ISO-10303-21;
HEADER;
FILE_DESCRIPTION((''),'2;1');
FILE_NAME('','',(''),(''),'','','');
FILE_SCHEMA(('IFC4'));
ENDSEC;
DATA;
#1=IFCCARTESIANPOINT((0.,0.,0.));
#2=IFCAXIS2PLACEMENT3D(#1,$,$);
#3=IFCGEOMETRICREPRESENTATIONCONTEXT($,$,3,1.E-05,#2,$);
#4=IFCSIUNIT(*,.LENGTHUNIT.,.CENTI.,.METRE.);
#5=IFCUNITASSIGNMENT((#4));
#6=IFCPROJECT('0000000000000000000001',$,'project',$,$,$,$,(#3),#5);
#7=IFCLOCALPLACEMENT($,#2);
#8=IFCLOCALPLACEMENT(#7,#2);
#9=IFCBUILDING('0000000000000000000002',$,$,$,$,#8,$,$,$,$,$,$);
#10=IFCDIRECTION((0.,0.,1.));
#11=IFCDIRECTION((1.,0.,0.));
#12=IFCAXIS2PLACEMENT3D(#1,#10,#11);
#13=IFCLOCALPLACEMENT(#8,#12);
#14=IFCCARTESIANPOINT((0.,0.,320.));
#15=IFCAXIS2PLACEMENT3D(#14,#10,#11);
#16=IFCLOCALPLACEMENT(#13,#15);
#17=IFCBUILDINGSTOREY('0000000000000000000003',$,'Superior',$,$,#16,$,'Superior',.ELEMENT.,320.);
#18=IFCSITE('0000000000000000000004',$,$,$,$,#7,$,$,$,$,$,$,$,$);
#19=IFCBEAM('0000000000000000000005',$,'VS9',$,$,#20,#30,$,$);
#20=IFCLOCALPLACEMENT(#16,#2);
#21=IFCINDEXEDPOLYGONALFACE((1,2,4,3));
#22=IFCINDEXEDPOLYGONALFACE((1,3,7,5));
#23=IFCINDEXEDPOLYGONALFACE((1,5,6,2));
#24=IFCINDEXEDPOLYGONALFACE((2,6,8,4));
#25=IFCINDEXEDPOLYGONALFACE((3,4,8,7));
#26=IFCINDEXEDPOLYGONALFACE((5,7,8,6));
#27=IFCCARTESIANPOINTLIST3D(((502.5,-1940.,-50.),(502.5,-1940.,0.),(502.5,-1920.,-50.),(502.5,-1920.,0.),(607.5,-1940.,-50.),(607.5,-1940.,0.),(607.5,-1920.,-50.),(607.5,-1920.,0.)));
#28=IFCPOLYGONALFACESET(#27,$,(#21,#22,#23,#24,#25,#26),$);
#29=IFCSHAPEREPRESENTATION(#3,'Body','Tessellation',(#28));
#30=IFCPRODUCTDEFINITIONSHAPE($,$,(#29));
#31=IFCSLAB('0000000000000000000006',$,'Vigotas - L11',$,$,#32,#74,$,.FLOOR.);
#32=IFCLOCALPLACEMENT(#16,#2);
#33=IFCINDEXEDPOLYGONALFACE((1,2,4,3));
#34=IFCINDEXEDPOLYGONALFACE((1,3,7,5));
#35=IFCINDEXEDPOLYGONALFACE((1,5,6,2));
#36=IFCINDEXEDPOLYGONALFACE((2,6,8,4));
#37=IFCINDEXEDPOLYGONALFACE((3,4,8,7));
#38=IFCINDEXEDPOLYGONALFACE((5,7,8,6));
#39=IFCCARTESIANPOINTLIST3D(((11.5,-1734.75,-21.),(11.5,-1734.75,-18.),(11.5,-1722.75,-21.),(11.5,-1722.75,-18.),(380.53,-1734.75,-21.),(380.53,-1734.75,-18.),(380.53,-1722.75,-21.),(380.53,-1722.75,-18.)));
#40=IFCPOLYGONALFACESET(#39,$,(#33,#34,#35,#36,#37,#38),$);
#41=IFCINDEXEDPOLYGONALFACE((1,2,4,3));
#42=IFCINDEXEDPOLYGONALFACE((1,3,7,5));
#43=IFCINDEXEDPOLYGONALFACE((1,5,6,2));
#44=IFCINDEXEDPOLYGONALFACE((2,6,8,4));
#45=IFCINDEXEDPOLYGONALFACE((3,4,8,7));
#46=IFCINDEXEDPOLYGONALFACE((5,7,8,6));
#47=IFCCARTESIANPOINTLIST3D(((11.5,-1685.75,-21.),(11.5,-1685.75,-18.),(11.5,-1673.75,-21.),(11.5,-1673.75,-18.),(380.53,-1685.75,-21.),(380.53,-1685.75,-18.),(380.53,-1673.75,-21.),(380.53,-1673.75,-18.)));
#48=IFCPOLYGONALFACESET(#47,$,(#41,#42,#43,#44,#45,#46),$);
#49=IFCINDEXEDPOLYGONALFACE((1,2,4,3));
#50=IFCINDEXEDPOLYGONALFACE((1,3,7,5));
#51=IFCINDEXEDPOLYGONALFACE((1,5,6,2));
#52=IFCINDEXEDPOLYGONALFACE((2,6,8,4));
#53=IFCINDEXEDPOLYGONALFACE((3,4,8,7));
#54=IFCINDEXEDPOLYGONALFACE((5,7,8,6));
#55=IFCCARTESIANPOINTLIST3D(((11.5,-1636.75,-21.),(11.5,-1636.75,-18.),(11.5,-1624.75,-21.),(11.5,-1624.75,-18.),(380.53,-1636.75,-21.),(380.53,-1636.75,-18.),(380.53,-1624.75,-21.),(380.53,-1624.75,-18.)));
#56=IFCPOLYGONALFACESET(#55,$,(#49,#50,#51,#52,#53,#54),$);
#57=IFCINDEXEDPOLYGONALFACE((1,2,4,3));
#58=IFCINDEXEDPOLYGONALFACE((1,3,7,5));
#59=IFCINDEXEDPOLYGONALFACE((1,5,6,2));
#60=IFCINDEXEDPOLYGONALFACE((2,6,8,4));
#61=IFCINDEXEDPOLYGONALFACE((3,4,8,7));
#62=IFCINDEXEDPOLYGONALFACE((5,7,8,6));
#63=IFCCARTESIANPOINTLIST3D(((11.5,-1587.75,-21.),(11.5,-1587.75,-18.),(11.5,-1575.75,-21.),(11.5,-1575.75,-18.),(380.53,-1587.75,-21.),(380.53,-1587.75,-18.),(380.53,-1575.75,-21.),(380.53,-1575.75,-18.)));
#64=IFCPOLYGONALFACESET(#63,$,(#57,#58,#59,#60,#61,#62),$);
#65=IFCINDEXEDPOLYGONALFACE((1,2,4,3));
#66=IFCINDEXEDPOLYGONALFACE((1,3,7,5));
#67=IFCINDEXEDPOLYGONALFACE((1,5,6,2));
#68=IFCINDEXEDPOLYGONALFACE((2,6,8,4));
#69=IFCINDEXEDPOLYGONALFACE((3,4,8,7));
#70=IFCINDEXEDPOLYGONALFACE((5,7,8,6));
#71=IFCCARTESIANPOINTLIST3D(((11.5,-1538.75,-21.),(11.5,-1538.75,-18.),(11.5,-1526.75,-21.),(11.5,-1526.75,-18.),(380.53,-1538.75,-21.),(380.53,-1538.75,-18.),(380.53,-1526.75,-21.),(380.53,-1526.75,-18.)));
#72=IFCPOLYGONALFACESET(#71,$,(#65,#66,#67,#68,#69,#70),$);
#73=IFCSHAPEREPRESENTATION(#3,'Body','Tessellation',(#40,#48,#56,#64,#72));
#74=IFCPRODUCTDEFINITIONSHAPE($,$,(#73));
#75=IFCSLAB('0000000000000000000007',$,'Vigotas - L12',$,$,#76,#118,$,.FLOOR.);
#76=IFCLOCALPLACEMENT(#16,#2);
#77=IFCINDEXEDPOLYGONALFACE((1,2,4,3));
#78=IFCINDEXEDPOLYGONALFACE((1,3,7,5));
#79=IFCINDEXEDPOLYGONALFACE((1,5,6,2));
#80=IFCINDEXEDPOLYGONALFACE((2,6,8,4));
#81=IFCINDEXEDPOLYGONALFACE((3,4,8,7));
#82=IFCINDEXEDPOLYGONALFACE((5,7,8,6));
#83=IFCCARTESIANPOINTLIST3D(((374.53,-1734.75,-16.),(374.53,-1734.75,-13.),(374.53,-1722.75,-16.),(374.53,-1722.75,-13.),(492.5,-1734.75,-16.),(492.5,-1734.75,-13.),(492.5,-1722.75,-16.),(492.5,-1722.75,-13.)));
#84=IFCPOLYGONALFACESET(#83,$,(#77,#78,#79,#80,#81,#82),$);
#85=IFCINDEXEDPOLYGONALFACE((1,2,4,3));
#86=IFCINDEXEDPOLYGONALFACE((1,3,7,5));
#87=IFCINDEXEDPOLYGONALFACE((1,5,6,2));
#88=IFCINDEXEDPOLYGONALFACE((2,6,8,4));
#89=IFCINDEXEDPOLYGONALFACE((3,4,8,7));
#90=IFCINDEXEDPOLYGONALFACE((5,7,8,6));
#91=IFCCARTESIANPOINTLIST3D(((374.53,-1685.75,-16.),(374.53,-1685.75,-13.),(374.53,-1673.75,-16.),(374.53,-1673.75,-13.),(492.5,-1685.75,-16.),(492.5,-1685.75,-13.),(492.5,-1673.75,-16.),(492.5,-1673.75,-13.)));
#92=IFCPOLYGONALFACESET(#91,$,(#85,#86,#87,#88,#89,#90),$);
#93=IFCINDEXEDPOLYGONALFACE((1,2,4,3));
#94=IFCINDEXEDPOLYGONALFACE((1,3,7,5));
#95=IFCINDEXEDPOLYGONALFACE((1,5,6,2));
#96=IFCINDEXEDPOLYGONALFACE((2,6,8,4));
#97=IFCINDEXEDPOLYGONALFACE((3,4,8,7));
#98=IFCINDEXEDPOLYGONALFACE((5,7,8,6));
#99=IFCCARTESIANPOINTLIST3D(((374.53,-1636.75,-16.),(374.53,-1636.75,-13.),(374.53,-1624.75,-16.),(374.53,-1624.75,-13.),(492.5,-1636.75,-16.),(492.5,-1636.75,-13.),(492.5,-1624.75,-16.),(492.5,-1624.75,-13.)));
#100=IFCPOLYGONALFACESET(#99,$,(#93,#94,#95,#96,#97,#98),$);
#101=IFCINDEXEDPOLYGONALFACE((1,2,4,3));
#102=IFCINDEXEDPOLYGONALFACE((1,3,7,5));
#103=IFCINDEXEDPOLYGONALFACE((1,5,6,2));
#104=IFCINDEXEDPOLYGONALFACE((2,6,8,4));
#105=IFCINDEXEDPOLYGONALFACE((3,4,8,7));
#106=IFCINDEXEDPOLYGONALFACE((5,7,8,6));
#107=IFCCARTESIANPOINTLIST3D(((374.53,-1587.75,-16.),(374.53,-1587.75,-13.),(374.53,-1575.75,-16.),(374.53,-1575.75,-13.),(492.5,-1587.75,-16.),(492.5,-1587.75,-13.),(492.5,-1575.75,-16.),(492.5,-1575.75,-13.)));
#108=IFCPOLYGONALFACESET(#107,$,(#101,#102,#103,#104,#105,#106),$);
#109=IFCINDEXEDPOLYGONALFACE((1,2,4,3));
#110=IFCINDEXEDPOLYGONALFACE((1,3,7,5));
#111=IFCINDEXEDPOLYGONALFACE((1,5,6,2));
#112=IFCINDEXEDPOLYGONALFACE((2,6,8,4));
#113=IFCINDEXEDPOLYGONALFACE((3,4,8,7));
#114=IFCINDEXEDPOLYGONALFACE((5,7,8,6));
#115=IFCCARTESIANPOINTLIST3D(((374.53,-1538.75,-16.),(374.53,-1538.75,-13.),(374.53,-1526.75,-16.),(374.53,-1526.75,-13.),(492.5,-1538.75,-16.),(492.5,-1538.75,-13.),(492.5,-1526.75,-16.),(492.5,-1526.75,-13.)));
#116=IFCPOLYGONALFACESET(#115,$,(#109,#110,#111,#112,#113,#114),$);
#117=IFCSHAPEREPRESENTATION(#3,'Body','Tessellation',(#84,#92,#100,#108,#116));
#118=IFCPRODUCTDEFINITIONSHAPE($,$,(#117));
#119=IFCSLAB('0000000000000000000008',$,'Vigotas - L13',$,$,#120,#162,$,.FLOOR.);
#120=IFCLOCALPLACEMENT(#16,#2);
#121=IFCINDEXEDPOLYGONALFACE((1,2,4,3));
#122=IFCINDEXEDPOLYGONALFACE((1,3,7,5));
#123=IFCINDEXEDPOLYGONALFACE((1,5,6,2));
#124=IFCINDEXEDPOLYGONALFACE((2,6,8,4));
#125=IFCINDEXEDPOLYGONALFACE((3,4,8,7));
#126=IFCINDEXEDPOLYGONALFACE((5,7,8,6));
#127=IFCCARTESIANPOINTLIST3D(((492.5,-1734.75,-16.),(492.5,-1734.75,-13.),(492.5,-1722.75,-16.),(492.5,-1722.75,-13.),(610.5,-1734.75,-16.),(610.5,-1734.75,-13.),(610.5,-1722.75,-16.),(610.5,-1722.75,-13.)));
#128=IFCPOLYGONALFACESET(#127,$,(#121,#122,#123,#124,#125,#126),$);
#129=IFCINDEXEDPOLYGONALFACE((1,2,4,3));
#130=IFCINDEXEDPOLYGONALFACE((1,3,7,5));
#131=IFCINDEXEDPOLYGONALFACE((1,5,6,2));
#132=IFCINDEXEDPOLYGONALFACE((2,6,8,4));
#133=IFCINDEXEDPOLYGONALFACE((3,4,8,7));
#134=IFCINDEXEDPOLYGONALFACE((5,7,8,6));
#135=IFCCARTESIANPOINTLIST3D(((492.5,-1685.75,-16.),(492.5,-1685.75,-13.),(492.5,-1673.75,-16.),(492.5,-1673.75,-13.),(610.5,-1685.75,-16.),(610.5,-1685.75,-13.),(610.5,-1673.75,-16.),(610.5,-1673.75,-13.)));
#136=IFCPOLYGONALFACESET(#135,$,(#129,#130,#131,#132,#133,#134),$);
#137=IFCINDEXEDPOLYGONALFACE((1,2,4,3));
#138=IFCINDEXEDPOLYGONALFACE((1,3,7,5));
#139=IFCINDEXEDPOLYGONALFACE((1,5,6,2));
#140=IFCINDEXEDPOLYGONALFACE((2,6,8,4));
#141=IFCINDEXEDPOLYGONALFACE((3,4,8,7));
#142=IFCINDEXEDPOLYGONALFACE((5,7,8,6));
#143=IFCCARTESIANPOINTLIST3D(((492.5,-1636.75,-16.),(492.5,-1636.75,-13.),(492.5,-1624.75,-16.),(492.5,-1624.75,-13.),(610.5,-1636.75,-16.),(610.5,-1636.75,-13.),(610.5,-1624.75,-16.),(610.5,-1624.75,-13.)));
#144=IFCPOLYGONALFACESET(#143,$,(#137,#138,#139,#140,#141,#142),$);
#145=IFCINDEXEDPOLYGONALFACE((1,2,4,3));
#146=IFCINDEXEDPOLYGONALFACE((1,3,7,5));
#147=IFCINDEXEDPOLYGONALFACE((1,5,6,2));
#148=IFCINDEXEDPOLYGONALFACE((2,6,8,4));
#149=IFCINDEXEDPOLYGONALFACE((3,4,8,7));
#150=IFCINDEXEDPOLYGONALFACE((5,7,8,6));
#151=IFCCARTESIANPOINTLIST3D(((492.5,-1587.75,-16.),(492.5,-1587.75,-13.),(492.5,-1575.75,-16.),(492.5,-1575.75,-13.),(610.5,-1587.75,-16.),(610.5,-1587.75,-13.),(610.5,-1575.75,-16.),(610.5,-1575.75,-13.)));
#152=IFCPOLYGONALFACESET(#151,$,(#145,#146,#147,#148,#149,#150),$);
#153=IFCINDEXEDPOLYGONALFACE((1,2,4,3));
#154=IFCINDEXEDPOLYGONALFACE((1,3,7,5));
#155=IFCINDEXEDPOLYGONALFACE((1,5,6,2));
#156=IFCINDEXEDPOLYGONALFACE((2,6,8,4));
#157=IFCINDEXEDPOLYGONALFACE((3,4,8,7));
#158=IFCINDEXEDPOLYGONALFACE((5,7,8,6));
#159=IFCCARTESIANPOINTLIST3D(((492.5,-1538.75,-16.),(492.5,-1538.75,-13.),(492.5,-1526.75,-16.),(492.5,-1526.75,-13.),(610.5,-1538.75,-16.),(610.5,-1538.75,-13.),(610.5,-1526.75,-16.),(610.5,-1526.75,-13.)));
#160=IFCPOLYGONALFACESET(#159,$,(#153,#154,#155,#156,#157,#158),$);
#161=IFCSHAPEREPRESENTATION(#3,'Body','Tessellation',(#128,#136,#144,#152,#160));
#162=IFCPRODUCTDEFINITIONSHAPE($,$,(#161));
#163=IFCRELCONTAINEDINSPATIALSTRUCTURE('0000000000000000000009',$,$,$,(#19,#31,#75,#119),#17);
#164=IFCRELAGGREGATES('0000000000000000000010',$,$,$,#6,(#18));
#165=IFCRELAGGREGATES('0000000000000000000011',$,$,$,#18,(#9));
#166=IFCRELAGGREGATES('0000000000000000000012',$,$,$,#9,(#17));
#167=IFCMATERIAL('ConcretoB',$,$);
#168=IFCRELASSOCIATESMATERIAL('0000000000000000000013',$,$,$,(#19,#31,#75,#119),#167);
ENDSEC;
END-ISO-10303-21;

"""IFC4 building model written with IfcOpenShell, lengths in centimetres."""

from ifc_helpers import new_model, si_unit, frame, origin, origin_with_axes, place, context, project, spatial, polyline, outline, extrude, material, element, save


model = new_model("IFC4")

# Units and contexts
context_of_model = context(None, 3, precision=1e-05, world=origin())
ifc_project = project(units=[si_unit("LENGTHUNIT", "METRE", prefix="CENTI")], contexts=[context_of_model])

# Site, building, storey
site_placement = place(None, origin())
site = spatial("IfcSite", under=ifc_project, at=site_placement)
building_placement = place(site_placement, origin())
building = spatial("IfcBuilding", under=site, at=building_placement)
placement = place(building_placement, origin_with_axes())
storey_placement = place(placement, frame((0.0, 0.0, 320.0), z_axis=(0.0, 0.0, 1.0), x_axis=(1.0, 0.0, 0.0)))
storey = spatial("IfcBuildingStorey", under=building, at=storey_placement, Name="Superior", LongName="Superior", CompositionType="ELEMENT", Elevation=320.0)

# Shared definitions
ifc_material = material(Name="ConcretoB")

# Beam
beam_1_placement = place(storey_placement, frame((555.0, -1930.0, 0.0), z_axis=(0.0, 0.0, 1.0), x_axis=(1.0, 0.0, 0.0)))
element("IfcBeam", 1, at=beam_1_placement, inside=storey, material=ifc_material, Name="VS9", context=context_of_model, shape_type="SolidModel", body=[
    extrude(outline(polyline([(-10.0, -25.0), (10.0, -25.0), (10.0, 25.0), (-10.0, 25.0), (-10.0, -25.0)])), frame((-52.5, 0.0, -25.0), z_axis=(1.0, 0.0, 0.0), x_axis=(0.0, -1.0, 0.0)), (0.0, 0.0, 1.0), 105.0),
])

# Slabs
slab_1_placement = place(storey_placement, frame((196.01, -1630.75, -18.0), z_axis=(0.0, 0.0, 1.0), x_axis=(1.0, 0.0, 0.0)))
element("IfcSlab", 2, at=slab_1_placement, inside=storey, material=ifc_material, Name="Vigotas - L11", PredefinedType="FLOOR", context=context_of_model, shape_type="SolidModel", body=[
    extrude(outline(polyline([(6.0, 1.5), (-6.0, 1.5), (-6.0, -1.5), (6.0, -1.5), (6.0, 1.5), (6.0, 1.5)])), frame((-184.51, -98.0, -1.5), z_axis=(1.0, 0.0, 0.0), x_axis=(0.0, -1.0, 0.0)), (0.0, 0.0, 1.0), 369.03),
    extrude(outline(polyline([(6.0, 1.5), (-6.0, 1.5), (-6.0, -1.5), (6.0, -1.5), (6.0, 1.5), (6.0, 1.5)])), frame((-184.51, -49.0, -1.5), z_axis=(1.0, 0.0, 0.0), x_axis=(0.0, -1.0, 0.0)), (0.0, 0.0, 1.0), 369.03),
    extrude(outline(polyline([(6.0, 1.5), (-6.0, 1.5), (-6.0, -1.5), (6.0, -1.5), (6.0, 1.5), (6.0, 1.5)])), frame((-184.51, 0.0, -1.5), z_axis=(1.0, 0.0, 0.0), x_axis=(0.0, -1.0, 0.0)), (0.0, 0.0, 1.0), 369.03),
    extrude(outline(polyline([(6.0, 1.5), (-6.0, 1.5), (-6.0, -1.5), (6.0, -1.5), (6.0, 1.5), (6.0, 1.5)])), frame((-184.51, 49.0, -1.5), z_axis=(1.0, 0.0, 0.0), x_axis=(0.0, -1.0, 0.0)), (0.0, 0.0, 1.0), 369.03),
    extrude(outline(polyline([(6.0, 1.5), (-6.0, 1.5), (-6.0, -1.5), (6.0, -1.5), (6.0, 1.5), (6.0, 1.5)])), frame((-184.51, 98.0, -1.5), z_axis=(1.0, 0.0, 0.0), x_axis=(0.0, -1.0, 0.0)), (0.0, 0.0, 1.0), 369.03),
])
slab_2_placement = place(storey_placement, frame((433.51, -1630.75, -13.0), z_axis=(0.0, 0.0, 1.0), x_axis=(1.0, 0.0, 0.0)))
element("IfcSlab", 3, at=slab_2_placement, inside=storey, material=ifc_material, Name="Vigotas - L12", PredefinedType="FLOOR", context=context_of_model, shape_type="SolidModel", body=[
    extrude(outline(polyline([(6.0, 1.5), (-6.0, 1.5), (-6.0, -1.5), (6.0, -1.5), (6.0, 1.5), (6.0, 1.5)])), frame((-58.98, -98.0, -1.5), z_axis=(1.0, 0.0, 0.0), x_axis=(0.0, -1.0, 0.0)), (0.0, 0.0, 1.0), 117.97),
    extrude(outline(polyline([(6.0, 1.5), (-6.0, 1.5), (-6.0, -1.5), (6.0, -1.5), (6.0, 1.5), (6.0, 1.5)])), frame((-58.98, -49.0, -1.5), z_axis=(1.0, 0.0, 0.0), x_axis=(0.0, -1.0, 0.0)), (0.0, 0.0, 1.0), 117.97),
    extrude(outline(polyline([(6.0, 1.5), (-6.0, 1.5), (-6.0, -1.5), (6.0, -1.5), (6.0, 1.5), (6.0, 1.5)])), frame((-58.98, 0.0, -1.5), z_axis=(1.0, 0.0, 0.0), x_axis=(0.0, -1.0, 0.0)), (0.0, 0.0, 1.0), 117.97),
    extrude(outline(polyline([(6.0, 1.5), (-6.0, 1.5), (-6.0, -1.5), (6.0, -1.5), (6.0, 1.5), (6.0, 1.5)])), frame((-58.98, 49.0, -1.5), z_axis=(1.0, 0.0, 0.0), x_axis=(0.0, -1.0, 0.0)), (0.0, 0.0, 1.0), 117.97),
    extrude(outline(polyline([(6.0, 1.5), (-6.0, 1.5), (-6.0, -1.5), (6.0, -1.5), (6.0, 1.5), (6.0, 1.5)])), frame((-58.98, 98.0, -1.5), z_axis=(1.0, 0.0, 0.0), x_axis=(0.0, -1.0, 0.0)), (0.0, 0.0, 1.0), 117.97),
])
slab_3_placement = place(storey_placement, frame((551.5, -1630.75, -13.0), z_axis=(0.0, 0.0, 1.0), x_axis=(1.0, 0.0, 0.0)))
element("IfcSlab", 4, at=slab_3_placement, inside=storey, material=ifc_material, Name="Vigotas - L13", PredefinedType="FLOOR", context=context_of_model, shape_type="SolidModel", body=[
    extrude(outline(polyline([(6.0, 1.5), (-6.0, 1.5), (-6.0, -1.5), (6.0, -1.5), (6.0, 1.5), (6.0, 1.5)])), frame((-59.0, -98.0, -1.5), z_axis=(1.0, 0.0, 0.0), x_axis=(0.0, -1.0, 0.0)), (0.0, 0.0, 1.0), 118.0),
    extrude(outline(polyline([(6.0, 1.5), (-6.0, 1.5), (-6.0, -1.5), (6.0, -1.5), (6.0, 1.5), (6.0, 1.5)])), frame((-59.0, -49.0, -1.5), z_axis=(1.0, 0.0, 0.0), x_axis=(0.0, -1.0, 0.0)), (0.0, 0.0, 1.0), 118.0),
    extrude(outline(polyline([(6.0, 1.5), (-6.0, 1.5), (-6.0, -1.5), (6.0, -1.5), (6.0, 1.5), (6.0, 1.5)])), frame((-59.0, 0.0, -1.5), z_axis=(1.0, 0.0, 0.0), x_axis=(0.0, -1.0, 0.0)), (0.0, 0.0, 1.0), 118.0),
    extrude(outline(polyline([(6.0, 1.5), (-6.0, 1.5), (-6.0, -1.5), (6.0, -1.5), (6.0, 1.5), (6.0, 1.5)])), frame((-59.0, 49.0, -1.5), z_axis=(1.0, 0.0, 0.0), x_axis=(0.0, -1.0, 0.0)), (0.0, 0.0, 1.0), 118.0),
    extrude(outline(polyline([(6.0, 1.5), (-6.0, 1.5), (-6.0, -1.5), (6.0, -1.5), (6.0, 1.5), (6.0, 1.5)])), frame((-59.0, 98.0, -1.5), z_axis=(1.0, 0.0, 0.0), x_axis=(0.0, -1.0, 0.0)), (0.0, 0.0, 1.0), 118.0),
])

save(model, "model.ifc")
